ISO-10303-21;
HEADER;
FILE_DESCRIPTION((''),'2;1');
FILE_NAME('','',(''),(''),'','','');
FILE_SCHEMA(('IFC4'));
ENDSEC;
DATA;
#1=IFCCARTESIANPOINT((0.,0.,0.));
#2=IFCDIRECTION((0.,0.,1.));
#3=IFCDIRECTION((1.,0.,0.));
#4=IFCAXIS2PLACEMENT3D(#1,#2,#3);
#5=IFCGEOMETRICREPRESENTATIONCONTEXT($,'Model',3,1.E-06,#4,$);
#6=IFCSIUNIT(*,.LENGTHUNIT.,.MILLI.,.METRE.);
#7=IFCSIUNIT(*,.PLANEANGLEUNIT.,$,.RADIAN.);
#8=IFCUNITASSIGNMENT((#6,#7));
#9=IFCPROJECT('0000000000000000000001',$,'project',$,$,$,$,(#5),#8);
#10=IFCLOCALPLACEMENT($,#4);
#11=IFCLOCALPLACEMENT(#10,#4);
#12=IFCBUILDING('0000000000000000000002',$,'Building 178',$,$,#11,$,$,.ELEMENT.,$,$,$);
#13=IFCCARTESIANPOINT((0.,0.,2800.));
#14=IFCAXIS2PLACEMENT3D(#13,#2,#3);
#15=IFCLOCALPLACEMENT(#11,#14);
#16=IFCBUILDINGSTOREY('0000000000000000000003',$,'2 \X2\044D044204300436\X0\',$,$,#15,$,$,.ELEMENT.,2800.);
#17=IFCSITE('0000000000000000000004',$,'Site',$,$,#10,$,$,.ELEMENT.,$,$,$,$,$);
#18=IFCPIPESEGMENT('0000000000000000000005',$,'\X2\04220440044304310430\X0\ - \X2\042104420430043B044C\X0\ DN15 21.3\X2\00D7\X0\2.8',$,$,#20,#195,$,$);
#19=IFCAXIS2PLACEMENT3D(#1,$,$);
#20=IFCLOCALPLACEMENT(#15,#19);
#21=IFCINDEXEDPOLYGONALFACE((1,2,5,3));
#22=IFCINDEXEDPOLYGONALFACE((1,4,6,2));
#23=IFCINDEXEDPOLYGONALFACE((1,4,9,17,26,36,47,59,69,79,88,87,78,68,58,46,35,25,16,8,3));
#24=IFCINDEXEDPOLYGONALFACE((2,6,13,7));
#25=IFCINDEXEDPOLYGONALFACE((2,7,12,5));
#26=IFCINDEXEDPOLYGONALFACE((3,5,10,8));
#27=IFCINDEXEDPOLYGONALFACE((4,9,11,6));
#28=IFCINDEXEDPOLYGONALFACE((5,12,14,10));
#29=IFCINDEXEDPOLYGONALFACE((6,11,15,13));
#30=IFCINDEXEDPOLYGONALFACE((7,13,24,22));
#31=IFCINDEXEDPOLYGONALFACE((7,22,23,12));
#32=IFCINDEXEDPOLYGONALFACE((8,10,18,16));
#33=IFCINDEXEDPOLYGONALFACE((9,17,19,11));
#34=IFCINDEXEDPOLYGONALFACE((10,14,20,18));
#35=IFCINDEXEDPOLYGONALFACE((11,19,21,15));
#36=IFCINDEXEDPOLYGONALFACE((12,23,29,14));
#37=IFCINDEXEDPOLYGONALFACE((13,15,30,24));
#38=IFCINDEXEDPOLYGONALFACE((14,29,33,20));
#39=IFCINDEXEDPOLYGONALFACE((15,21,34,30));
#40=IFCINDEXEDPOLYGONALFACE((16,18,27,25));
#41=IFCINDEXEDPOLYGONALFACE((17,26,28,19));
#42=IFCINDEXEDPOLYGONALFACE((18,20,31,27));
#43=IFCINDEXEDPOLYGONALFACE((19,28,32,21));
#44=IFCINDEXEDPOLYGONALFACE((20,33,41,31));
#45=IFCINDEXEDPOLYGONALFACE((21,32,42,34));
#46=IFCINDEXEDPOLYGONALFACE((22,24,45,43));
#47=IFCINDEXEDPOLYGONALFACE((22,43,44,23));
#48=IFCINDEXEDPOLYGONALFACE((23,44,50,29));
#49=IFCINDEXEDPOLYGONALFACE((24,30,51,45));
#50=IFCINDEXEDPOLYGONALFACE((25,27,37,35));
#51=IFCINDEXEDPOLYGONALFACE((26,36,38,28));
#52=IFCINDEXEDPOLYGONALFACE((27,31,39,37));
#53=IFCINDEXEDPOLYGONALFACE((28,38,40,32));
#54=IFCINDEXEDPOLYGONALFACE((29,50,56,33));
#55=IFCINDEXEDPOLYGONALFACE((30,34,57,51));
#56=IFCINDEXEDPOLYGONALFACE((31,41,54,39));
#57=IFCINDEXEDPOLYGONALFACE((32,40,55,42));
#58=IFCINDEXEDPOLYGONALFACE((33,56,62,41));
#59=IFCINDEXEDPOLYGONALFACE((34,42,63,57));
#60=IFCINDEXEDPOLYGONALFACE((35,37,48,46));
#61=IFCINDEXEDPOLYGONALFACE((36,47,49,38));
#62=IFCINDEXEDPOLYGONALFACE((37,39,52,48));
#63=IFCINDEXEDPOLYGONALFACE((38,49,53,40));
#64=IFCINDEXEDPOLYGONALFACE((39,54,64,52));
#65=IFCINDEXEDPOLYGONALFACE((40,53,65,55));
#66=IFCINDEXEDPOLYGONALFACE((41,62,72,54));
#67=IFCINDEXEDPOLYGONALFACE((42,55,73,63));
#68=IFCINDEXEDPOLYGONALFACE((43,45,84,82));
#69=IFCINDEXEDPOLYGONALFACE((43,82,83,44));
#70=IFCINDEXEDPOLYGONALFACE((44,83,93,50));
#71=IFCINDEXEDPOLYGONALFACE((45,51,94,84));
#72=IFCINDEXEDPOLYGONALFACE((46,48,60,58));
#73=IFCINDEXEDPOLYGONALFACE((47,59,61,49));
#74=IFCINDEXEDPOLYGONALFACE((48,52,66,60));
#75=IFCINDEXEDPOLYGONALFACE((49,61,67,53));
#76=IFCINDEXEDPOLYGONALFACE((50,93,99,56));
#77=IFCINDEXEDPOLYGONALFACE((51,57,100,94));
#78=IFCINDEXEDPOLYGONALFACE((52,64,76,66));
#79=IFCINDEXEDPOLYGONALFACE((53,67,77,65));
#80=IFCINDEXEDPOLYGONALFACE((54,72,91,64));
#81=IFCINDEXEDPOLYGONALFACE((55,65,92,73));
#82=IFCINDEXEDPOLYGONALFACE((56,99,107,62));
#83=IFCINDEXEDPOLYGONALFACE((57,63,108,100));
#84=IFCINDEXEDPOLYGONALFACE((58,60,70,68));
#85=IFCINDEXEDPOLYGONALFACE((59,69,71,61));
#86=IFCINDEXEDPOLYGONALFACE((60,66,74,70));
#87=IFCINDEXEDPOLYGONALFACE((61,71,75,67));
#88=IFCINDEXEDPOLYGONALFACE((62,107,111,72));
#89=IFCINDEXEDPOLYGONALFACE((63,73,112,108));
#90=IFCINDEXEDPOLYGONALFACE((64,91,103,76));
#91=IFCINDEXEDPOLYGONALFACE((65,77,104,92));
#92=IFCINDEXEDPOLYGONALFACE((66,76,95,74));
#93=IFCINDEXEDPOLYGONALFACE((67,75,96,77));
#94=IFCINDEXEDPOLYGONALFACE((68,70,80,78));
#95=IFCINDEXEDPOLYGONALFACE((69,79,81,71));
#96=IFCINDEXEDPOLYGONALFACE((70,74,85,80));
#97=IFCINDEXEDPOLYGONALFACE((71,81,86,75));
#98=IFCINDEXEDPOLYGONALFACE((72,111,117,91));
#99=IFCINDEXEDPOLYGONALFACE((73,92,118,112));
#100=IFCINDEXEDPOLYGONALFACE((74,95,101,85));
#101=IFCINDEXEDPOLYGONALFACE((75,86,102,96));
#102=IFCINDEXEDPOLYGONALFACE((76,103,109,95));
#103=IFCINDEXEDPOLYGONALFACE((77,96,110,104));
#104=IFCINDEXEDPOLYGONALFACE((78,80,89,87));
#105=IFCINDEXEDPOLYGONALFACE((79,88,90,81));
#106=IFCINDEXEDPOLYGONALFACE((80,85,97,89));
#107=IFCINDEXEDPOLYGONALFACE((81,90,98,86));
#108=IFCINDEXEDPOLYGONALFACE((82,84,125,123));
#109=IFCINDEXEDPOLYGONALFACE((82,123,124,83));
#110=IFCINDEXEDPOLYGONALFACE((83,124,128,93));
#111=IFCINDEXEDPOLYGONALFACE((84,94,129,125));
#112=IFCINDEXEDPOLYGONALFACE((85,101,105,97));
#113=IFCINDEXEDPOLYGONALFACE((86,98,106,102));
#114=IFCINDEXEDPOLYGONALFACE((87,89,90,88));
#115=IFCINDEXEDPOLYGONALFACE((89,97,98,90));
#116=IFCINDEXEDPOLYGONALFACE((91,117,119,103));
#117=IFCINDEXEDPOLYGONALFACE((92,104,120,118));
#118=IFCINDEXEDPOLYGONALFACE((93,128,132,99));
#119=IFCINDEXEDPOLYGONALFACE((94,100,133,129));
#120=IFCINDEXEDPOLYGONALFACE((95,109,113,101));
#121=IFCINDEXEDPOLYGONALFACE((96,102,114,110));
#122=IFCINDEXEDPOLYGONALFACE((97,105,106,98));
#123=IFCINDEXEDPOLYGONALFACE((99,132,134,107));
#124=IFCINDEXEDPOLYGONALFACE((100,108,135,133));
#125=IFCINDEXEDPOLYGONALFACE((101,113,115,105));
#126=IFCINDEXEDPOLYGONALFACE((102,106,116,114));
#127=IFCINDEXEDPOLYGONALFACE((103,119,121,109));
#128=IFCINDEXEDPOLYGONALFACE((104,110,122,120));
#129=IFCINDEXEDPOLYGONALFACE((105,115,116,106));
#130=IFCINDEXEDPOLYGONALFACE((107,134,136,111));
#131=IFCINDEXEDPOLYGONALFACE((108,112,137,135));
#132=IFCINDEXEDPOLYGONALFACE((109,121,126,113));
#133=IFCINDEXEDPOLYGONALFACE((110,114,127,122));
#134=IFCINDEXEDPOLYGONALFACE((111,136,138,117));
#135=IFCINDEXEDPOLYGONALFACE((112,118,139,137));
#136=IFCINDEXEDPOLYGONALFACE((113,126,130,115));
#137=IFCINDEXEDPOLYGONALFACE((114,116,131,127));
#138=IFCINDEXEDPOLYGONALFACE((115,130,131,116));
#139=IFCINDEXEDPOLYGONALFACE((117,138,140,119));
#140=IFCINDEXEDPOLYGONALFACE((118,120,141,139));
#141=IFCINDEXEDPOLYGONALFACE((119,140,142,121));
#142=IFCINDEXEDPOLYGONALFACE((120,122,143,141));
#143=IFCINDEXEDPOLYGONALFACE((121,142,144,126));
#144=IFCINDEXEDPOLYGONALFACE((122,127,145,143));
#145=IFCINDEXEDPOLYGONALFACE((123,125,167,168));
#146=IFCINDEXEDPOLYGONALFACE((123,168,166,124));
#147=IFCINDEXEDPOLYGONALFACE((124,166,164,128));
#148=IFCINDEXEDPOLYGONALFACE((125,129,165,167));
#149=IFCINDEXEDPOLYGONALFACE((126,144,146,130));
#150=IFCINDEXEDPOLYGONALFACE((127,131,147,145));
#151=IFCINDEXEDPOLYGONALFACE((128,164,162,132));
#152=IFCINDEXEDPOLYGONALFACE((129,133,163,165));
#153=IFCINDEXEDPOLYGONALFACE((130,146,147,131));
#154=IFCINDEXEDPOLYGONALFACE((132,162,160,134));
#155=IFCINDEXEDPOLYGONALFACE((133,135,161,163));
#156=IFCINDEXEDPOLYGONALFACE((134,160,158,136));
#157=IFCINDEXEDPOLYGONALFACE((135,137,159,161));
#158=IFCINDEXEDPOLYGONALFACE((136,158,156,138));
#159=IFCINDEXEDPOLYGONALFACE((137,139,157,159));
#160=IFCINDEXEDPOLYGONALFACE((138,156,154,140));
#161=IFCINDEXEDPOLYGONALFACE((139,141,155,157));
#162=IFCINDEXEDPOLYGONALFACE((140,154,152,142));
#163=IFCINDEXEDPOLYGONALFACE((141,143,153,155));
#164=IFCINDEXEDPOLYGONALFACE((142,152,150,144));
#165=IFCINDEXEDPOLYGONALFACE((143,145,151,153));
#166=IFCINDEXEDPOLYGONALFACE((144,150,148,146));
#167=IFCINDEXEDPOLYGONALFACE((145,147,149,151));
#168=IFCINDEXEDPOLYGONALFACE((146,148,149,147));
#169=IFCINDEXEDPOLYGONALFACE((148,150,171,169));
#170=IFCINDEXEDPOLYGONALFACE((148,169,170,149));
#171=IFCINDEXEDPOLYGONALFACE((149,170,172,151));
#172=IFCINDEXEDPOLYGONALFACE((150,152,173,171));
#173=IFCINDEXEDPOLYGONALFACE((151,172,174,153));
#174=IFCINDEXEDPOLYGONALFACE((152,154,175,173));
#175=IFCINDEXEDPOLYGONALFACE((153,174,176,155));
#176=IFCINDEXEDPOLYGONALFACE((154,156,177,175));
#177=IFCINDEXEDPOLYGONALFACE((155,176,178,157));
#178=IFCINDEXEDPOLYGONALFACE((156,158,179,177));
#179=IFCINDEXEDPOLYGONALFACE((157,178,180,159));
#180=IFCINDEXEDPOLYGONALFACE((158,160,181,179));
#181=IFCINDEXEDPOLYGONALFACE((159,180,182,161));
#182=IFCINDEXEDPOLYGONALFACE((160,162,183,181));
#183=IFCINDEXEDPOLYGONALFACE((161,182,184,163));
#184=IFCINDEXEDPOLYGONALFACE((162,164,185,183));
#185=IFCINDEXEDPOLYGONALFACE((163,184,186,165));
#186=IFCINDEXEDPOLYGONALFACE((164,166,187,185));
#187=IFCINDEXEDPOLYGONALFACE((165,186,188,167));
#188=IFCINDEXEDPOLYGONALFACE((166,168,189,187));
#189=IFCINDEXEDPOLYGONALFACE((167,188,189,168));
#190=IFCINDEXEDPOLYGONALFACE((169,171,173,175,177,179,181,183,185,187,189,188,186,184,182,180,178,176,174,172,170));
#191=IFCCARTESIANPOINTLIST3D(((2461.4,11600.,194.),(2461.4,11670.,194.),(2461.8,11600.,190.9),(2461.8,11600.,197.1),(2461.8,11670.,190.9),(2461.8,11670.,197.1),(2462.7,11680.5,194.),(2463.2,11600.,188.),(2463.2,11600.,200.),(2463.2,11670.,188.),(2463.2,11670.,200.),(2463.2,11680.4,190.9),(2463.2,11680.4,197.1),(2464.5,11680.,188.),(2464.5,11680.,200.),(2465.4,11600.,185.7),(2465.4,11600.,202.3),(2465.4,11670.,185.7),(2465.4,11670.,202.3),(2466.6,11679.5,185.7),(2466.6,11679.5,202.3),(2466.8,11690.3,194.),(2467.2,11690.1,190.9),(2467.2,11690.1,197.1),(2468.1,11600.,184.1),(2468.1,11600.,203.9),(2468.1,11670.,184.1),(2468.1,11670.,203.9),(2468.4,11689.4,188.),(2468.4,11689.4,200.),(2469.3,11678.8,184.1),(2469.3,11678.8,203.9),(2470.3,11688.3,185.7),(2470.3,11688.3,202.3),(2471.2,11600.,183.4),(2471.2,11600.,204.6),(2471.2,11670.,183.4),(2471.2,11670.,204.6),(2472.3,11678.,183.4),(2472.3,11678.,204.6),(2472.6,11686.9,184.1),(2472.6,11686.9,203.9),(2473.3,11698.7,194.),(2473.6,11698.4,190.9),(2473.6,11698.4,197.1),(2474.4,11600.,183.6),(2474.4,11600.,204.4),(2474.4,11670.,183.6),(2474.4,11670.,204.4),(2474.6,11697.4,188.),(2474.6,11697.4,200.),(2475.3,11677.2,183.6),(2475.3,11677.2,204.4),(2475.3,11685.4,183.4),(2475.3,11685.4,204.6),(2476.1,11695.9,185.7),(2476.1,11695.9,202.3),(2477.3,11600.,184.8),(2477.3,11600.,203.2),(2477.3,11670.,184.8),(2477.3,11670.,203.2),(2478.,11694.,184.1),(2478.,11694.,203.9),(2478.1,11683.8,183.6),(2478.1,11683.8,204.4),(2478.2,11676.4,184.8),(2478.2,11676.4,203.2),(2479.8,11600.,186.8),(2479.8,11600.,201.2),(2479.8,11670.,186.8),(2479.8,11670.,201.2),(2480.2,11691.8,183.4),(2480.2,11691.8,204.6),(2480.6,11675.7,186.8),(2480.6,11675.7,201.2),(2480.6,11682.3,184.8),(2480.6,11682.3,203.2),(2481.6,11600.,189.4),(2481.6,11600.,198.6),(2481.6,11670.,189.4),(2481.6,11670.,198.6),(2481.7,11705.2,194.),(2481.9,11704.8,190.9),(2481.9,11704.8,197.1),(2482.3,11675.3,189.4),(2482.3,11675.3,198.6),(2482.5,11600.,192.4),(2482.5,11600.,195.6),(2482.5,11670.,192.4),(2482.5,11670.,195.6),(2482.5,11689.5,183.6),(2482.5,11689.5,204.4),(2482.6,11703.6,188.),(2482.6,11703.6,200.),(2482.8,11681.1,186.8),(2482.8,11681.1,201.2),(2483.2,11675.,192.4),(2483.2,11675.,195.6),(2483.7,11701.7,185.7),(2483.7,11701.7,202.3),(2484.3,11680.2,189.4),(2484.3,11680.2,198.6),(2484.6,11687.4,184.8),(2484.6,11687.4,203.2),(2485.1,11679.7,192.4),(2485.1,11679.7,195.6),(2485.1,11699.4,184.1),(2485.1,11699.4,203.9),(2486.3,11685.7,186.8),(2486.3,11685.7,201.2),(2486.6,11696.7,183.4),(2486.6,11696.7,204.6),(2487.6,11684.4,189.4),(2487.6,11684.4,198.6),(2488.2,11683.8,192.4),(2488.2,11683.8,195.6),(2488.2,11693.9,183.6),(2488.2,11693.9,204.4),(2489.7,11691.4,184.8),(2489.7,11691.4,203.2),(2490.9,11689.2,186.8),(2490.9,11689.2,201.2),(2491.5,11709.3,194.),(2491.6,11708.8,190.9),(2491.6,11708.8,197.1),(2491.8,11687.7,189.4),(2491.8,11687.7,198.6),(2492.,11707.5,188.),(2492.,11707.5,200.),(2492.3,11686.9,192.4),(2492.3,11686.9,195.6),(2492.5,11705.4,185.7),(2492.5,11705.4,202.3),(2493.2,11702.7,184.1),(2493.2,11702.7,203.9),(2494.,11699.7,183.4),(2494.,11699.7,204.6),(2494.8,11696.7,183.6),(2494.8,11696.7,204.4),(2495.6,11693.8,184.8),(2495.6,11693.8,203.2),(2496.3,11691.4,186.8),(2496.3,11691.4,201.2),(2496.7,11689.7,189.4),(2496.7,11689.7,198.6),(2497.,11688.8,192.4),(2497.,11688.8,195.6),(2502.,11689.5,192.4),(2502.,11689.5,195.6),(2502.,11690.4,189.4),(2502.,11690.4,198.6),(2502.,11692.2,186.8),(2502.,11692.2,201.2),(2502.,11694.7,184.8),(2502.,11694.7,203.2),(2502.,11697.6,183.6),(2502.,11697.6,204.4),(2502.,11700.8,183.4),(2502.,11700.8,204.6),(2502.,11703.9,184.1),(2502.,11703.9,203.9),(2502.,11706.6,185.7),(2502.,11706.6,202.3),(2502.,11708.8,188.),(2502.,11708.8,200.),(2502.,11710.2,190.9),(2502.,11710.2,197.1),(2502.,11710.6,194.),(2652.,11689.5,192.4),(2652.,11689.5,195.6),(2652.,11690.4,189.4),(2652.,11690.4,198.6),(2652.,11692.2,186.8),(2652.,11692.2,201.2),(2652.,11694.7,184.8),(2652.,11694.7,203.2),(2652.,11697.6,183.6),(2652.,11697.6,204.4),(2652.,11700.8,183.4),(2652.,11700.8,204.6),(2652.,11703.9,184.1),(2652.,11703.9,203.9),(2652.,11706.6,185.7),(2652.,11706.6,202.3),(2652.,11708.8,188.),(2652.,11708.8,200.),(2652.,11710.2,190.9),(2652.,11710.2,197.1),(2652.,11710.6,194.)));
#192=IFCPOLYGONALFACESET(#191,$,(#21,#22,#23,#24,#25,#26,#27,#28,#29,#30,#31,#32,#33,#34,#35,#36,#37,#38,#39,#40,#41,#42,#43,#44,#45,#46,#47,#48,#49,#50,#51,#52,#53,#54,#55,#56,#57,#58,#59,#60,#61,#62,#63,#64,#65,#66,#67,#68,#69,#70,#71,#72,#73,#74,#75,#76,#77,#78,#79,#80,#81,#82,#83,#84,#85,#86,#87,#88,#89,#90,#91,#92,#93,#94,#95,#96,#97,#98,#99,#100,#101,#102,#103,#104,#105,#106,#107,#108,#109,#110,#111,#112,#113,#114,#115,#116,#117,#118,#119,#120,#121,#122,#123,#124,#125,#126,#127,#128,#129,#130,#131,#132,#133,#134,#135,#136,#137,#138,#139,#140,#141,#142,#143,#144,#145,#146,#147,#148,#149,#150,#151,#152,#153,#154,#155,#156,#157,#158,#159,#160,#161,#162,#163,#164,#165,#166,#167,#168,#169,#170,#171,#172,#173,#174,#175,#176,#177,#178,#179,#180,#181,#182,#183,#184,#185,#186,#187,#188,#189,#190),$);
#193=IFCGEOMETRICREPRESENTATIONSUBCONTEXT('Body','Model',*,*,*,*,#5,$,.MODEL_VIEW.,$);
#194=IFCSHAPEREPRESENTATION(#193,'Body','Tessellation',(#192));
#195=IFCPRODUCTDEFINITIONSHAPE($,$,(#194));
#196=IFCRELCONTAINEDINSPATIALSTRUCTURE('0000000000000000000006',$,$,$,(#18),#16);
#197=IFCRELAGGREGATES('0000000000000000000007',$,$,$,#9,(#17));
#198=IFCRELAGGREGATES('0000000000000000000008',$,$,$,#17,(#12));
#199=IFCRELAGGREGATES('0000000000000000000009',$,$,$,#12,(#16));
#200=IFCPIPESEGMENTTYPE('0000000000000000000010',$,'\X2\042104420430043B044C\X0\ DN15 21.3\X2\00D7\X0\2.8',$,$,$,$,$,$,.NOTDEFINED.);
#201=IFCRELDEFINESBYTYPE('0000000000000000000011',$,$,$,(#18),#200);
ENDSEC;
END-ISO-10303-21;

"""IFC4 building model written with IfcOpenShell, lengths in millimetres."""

from ifc_helpers import new_model, entity, si_unit, frame, origin_with_axes, place, context, subcontext, project, spatial, source, transform, mapped, type_object, element, save


model = new_model("IFC4")

# Units and contexts
model_context = context("Model", 3, precision=1e-06, world=origin_with_axes())
body_context = subcontext(model_context, "Body", "Model", "MODEL_VIEW")
ifc_project = project(units=[si_unit("LENGTHUNIT", "METRE", prefix="MILLI"), si_unit("PLANEANGLEUNIT", "RADIAN")], contexts=[model_context])

# Site, building, storey
site_placement = place(None, origin_with_axes())
site = spatial("IfcSite", under=ifc_project, at=site_placement, Name="Site", CompositionType="ELEMENT")
building_placement = place(site_placement, origin_with_axes())
building = spatial("IfcBuilding", under=site, at=building_placement, Name="Building 178", CompositionType="ELEMENT")
storey_placement = place(building_placement, frame((0.0, 0.0, 2800.0), z_axis=(0.0, 0.0, 1.0), x_axis=(1.0, 0.0, 0.0)))
storey = spatial("IfcBuildingStorey", under=building, at=storey_placement, Name="2 этаж", CompositionType="ELEMENT", Elevation=2800.0)

# Pipe segment
pipe_segment_type = type_object("IfcPipeSegmentType", Name="Сталь DN15 21.3×2.8", PredefinedType="NOTDEFINED")
shared_shape_1 = source(origin_with_axes(), body_context, "Body", "AdvancedSweptSolid", [
    entity("IfcSweptDiskSolid", entity("IfcIndexedPolyCurve", entity("IfcCartesianPointList3D", [[0.0, 0.0, 0.0], [0.0, 0.0, -70.0], [8.8, 0.0, -91.2], [30.0, 0.0, -100.0], [180.0, 0.0, -100.0]]), [entity("IfcLineIndex", [1, 2]), entity("IfcArcIndex", [2, 3, 4]), entity("IfcLineIndex", [4, 5])]), 10.7),
])
for number, where, z_axis, x_axis, name in (
    (1, (2472.0, 11600.0, 194.0), (0.0, -1.0, 0.0), (1.0, 0.0, 0.0), "Труба - Сталь DN15 21.3×2.8"),
):
    element("IfcPipeSegment", number, at=place(storey_placement, frame(where, z_axis=z_axis, x_axis=x_axis)), inside=storey, type_object=pipe_segment_type, Name=name, context=body_context, shape_type="MappedRepresentation", body=[
        mapped(shared_shape_1, transform((0.0, 0.0, 0.0), x_axis=(1.0, 0.0, 0.0), y_axis=(0.0, 1.0, 0.0), z_axis=(0.0, 0.0, 1.0), scale=1.0)),
    ])

save(model, "model.ifc")
